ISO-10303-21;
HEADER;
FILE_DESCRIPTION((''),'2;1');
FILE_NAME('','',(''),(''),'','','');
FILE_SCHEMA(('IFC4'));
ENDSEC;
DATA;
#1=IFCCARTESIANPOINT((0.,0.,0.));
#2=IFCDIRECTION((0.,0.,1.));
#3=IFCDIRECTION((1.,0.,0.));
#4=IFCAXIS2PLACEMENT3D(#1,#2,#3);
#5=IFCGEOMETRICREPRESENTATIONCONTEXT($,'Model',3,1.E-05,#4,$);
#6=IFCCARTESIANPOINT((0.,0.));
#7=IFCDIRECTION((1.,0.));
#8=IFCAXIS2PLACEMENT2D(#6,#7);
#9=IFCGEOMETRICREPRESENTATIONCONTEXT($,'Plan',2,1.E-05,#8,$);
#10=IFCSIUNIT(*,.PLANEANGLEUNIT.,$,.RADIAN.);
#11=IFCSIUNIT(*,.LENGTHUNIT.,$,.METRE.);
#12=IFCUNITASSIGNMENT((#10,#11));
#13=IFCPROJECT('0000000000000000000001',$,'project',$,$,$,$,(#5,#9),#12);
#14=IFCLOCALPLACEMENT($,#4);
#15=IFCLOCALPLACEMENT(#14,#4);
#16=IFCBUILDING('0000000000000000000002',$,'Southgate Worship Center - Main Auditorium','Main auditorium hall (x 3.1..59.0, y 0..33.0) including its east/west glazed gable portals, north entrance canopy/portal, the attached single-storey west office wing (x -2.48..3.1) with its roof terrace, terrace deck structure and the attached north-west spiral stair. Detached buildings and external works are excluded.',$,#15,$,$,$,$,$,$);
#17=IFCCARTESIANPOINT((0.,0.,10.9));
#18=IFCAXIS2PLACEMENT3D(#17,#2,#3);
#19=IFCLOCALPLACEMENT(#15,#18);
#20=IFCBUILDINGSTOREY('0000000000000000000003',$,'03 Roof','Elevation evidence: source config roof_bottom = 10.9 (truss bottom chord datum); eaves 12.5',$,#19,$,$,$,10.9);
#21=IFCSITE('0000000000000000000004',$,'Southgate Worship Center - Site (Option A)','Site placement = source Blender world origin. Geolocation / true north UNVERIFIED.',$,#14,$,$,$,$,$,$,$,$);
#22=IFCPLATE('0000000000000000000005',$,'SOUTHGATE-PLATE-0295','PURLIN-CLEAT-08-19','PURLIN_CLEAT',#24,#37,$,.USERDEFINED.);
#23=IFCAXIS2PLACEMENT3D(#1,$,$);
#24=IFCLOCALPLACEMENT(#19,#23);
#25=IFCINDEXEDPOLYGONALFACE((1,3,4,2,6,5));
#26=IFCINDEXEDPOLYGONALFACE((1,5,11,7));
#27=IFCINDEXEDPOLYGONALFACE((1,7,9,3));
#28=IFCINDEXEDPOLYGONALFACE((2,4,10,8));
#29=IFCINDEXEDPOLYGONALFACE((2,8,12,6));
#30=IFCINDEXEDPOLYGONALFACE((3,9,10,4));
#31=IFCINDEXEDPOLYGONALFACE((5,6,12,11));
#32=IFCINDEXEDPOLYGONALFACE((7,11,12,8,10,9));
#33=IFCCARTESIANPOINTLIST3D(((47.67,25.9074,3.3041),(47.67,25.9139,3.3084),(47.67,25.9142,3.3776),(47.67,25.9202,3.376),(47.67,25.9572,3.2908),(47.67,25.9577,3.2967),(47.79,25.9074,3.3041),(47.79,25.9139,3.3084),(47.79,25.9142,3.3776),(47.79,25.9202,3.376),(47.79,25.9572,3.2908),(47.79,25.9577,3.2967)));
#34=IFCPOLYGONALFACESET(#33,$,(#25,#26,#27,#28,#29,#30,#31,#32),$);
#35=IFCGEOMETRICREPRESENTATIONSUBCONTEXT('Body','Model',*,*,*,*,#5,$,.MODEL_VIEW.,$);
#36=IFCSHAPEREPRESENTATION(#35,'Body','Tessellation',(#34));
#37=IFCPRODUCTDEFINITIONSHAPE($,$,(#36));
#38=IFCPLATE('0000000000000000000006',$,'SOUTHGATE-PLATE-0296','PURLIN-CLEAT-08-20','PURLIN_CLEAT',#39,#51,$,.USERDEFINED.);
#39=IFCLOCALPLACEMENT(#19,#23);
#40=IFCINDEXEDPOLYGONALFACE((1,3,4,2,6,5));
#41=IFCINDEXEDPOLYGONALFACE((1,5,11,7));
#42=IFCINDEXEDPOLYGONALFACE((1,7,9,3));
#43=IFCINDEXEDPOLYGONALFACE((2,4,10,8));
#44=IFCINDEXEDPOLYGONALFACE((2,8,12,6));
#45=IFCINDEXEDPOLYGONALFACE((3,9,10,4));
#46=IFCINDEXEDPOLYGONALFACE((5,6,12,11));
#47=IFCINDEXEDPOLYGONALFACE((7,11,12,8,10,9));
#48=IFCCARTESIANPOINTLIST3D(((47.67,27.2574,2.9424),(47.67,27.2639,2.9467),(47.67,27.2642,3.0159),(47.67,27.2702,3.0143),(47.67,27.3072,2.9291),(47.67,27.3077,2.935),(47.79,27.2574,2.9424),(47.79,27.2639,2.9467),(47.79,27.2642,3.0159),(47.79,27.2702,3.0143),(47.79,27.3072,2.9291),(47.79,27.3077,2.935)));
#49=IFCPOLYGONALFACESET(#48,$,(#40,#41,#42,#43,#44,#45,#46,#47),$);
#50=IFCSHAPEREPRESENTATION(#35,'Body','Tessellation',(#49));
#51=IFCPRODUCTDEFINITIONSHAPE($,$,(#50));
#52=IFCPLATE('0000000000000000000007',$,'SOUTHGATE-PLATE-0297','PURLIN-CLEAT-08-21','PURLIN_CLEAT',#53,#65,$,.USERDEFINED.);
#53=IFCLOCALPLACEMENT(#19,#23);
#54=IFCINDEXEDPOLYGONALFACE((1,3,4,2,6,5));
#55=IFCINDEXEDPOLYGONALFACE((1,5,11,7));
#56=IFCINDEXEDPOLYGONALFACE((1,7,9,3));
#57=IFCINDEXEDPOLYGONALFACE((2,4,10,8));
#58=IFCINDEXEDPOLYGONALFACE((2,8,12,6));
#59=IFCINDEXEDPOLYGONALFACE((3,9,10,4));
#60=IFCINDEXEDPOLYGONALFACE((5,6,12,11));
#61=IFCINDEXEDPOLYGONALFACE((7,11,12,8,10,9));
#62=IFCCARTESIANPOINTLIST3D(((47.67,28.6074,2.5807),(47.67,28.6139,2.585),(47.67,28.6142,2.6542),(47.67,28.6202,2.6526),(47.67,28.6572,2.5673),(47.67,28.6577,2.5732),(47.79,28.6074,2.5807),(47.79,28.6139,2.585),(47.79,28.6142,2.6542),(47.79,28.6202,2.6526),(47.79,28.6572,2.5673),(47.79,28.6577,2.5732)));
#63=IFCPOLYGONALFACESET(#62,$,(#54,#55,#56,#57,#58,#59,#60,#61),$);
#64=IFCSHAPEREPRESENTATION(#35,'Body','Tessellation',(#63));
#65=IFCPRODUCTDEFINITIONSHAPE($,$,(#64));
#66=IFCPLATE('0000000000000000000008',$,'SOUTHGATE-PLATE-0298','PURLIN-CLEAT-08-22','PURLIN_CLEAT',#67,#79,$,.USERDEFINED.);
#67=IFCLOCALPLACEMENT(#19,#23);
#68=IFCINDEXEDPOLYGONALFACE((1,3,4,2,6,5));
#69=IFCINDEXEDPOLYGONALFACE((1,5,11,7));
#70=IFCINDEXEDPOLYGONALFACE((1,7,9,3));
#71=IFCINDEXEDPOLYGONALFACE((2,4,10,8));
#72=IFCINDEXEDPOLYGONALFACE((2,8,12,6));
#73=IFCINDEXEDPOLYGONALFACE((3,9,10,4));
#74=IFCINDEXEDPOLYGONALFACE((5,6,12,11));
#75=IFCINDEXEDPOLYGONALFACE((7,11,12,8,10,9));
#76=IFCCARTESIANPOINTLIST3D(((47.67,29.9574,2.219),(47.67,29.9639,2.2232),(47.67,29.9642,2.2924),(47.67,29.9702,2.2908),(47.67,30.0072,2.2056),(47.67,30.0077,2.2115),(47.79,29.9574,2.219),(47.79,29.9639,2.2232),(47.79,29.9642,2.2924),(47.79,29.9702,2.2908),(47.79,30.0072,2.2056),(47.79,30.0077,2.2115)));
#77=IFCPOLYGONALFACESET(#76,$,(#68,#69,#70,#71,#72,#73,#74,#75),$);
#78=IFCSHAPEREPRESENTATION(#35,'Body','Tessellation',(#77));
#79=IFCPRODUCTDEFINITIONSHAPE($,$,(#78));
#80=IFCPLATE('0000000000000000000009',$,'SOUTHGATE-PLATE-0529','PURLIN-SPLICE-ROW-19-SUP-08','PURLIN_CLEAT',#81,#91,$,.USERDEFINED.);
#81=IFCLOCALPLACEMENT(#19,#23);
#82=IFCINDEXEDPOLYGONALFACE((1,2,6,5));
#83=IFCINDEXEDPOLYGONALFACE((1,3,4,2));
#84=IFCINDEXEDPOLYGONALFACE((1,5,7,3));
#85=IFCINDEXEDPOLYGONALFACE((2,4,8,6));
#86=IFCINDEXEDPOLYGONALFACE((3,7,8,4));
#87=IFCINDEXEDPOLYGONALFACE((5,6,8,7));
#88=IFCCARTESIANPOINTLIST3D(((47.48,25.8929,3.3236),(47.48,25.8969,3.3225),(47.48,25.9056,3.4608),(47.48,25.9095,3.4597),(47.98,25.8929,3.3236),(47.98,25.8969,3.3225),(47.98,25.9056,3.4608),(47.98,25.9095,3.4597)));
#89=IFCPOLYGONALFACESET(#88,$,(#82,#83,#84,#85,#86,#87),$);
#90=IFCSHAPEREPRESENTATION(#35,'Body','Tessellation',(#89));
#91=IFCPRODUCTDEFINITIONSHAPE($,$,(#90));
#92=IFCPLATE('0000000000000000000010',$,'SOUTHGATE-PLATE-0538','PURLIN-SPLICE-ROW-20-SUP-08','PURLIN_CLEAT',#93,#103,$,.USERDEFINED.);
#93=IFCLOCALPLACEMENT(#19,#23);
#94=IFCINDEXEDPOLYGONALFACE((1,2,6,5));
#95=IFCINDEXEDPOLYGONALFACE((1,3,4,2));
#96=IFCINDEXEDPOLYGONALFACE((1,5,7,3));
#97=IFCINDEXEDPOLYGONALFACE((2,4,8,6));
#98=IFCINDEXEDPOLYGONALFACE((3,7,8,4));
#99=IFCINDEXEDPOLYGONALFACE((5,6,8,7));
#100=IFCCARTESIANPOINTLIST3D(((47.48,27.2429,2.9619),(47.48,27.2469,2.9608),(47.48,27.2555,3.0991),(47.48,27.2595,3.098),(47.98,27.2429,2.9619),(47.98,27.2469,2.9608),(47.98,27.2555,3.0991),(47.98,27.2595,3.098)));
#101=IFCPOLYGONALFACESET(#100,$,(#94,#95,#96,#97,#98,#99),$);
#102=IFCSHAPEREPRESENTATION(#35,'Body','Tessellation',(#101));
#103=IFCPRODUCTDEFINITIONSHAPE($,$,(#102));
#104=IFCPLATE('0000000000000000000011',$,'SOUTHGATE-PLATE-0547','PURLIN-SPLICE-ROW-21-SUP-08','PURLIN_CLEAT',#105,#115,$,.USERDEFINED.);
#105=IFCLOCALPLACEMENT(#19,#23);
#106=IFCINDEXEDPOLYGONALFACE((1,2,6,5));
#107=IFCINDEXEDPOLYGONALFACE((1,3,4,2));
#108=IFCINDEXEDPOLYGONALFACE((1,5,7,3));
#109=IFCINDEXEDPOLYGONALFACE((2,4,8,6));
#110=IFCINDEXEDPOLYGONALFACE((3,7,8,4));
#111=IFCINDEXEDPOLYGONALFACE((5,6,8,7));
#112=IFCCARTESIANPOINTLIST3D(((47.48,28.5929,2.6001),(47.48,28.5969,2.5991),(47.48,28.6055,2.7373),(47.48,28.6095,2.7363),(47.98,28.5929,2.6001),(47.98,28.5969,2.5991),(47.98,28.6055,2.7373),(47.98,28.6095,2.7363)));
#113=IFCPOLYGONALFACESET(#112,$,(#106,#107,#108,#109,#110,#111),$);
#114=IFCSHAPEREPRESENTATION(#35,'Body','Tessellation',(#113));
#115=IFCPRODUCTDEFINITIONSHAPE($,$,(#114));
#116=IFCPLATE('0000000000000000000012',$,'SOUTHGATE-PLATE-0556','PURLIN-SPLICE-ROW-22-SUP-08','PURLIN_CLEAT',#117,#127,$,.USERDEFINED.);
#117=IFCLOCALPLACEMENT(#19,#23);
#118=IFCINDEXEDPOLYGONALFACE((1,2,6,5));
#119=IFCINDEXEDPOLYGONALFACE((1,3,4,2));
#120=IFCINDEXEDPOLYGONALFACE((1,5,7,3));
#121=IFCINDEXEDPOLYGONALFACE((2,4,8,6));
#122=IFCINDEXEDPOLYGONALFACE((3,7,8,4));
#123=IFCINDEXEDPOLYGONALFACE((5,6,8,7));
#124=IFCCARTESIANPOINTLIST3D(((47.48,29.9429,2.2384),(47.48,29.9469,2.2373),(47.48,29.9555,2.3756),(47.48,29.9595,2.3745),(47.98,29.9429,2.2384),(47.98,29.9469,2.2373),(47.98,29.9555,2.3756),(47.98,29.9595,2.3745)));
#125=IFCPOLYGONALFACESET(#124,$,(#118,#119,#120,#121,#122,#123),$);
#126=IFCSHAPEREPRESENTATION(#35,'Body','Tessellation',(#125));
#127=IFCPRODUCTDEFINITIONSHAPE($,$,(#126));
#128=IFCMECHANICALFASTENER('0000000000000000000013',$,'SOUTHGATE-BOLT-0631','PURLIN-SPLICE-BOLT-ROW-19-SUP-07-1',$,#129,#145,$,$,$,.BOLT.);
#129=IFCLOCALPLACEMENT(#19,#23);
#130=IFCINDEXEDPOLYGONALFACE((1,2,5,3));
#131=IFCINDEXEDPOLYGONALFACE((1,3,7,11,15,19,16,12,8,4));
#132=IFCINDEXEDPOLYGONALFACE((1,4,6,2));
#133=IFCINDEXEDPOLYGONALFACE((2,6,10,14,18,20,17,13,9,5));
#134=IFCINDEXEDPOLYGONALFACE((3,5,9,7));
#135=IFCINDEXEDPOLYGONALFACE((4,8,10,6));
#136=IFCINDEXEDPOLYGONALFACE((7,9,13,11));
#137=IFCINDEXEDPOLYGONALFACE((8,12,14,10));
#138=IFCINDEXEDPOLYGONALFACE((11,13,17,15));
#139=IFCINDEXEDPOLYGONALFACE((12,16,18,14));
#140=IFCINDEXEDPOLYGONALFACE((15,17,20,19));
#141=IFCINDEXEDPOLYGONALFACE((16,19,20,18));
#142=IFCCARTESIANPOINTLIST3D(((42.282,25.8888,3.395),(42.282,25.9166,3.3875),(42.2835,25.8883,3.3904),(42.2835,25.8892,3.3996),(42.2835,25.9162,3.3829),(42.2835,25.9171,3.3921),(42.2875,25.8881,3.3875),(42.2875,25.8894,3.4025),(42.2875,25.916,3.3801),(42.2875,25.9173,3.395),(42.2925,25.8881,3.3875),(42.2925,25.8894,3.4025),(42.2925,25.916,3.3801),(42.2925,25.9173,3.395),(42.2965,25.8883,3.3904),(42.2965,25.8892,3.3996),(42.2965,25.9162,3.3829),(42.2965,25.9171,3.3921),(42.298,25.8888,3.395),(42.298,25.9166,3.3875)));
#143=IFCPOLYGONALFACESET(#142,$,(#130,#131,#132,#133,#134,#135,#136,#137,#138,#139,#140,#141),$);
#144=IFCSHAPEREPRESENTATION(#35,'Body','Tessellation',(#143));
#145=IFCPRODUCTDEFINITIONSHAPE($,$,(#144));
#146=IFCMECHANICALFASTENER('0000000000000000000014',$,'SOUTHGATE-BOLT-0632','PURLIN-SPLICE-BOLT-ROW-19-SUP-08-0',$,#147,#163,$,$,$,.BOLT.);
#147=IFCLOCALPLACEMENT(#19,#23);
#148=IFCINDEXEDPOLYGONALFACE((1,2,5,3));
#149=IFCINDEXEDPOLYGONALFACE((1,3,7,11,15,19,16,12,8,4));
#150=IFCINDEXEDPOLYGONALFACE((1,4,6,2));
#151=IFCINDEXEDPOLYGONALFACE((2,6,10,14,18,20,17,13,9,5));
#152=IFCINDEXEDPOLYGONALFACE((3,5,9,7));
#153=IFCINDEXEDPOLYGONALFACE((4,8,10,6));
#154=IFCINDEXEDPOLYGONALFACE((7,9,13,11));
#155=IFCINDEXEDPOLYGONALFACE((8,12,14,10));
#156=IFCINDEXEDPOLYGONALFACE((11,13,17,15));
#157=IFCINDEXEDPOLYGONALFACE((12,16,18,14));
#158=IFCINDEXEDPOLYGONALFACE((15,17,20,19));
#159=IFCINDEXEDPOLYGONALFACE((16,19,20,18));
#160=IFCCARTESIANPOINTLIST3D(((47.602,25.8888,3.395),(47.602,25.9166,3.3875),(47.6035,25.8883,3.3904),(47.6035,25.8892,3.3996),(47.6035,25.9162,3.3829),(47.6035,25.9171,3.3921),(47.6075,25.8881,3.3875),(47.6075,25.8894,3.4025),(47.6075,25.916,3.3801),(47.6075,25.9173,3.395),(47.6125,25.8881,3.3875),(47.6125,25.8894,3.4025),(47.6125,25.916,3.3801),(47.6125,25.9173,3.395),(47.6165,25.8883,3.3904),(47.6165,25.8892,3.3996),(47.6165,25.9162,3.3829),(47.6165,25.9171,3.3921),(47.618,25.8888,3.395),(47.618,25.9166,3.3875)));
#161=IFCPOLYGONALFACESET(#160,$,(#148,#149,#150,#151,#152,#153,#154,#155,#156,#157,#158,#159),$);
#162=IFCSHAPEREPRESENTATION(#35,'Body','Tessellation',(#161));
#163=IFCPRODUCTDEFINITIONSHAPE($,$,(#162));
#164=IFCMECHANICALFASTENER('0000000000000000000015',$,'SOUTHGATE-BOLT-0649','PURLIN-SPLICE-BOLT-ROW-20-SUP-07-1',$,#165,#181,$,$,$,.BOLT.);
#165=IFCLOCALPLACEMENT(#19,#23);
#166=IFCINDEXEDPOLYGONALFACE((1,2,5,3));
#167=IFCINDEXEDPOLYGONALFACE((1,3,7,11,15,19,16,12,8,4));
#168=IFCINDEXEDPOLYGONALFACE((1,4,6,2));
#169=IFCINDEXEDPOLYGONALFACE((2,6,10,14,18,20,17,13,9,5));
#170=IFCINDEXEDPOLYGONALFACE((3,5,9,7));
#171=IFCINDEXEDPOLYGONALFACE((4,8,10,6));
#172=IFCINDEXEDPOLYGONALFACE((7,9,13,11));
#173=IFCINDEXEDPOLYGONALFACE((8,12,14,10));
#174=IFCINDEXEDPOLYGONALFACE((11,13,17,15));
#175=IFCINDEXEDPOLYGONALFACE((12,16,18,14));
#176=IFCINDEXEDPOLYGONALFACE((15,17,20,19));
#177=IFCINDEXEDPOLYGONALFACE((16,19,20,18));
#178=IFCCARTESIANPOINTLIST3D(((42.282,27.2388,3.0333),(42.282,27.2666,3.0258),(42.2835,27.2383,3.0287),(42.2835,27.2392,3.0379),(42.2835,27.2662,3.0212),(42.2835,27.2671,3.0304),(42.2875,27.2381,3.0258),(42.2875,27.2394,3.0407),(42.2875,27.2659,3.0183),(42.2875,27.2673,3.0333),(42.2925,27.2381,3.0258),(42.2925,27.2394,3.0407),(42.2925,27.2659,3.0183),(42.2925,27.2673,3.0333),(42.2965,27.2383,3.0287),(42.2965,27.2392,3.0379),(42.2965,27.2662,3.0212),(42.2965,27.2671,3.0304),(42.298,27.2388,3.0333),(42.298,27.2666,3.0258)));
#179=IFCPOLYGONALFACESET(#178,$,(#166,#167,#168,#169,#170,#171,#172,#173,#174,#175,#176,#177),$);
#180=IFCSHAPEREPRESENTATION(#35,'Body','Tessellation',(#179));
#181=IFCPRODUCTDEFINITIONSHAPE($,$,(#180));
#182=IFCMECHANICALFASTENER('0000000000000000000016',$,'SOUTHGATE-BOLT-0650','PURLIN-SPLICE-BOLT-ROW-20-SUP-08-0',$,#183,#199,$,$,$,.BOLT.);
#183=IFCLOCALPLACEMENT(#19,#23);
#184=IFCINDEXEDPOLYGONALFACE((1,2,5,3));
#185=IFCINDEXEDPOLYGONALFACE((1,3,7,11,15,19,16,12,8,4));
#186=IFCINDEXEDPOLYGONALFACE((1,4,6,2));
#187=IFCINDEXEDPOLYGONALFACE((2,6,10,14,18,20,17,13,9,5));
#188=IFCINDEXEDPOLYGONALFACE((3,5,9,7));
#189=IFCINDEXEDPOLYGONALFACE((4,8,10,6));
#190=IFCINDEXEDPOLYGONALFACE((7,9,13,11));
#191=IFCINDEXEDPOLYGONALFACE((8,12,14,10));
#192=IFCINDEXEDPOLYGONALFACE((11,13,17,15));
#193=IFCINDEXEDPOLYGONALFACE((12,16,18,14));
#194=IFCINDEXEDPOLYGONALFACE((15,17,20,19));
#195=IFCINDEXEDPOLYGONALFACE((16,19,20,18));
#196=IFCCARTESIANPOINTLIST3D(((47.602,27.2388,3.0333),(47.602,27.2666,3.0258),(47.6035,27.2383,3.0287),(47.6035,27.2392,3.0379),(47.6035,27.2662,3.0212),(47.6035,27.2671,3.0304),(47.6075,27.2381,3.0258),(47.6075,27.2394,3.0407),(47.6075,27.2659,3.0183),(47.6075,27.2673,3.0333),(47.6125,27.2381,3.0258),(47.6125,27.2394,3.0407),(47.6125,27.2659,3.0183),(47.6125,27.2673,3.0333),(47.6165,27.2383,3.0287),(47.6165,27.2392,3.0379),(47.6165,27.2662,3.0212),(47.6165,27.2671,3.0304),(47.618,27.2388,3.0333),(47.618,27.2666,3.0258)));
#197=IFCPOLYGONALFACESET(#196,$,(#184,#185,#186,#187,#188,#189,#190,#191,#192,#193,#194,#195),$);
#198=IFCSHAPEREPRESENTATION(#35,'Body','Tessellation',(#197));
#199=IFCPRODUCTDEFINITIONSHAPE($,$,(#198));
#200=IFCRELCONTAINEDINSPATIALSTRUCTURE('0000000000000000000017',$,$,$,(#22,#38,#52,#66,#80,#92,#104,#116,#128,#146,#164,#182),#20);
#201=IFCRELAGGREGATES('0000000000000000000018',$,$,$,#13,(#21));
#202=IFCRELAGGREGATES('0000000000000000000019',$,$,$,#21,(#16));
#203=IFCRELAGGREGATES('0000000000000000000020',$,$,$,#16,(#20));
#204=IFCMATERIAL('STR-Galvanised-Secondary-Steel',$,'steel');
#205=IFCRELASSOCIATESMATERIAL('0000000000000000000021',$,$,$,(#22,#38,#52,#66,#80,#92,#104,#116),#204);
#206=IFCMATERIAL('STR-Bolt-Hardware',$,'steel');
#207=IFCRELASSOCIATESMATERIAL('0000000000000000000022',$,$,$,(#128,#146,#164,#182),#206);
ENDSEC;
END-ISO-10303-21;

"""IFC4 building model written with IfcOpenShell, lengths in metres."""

from ifc_helpers import new_model, si_unit, frame, origin_with_axes, origin_2d_with_axis, place, context, subcontext, project, spatial, indexed_curve, outline, extrude, clip, halfspace, material, element, save


model = new_model("IFC4")

# Units and contexts
model_context = context("Model", 3, precision=1e-05, world=origin_with_axes())
plan_context = context("Plan", 2, precision=1e-05, world=origin_2d_with_axis())
body_context = subcontext(model_context, "Body", "Model", "MODEL_VIEW")
ifc_project = project(units=[si_unit("PLANEANGLEUNIT", "RADIAN"), si_unit("LENGTHUNIT", "METRE")], contexts=[model_context, plan_context])

# Site, building, storey
site_placement = place(None, origin_with_axes())
site = spatial("IfcSite", under=ifc_project, at=site_placement, Name="Southgate Worship Center - Site (Option A)", Description="Site placement = source Blender world origin. Geolocation / true north UNVERIFIED.")
building_placement = place(site_placement, origin_with_axes())
building = spatial("IfcBuilding", under=site, at=building_placement, Name="Southgate Worship Center - Main Auditorium", Description="Main auditorium hall (x 3.1..59.0, y 0..33.0) including its east/west glazed gable portals, north entrance canopy/portal, the attached single-storey west office wing (x -2.48..3.1) with its roof terrace, terrace deck structure and the attached north-west spiral stair. Detached buildings and external works are excluded.")
storey_placement = place(building_placement, frame((0.0, 0.0, 10.9), z_axis=(0.0, 0.0, 1.0), x_axis=(1.0, 0.0, 0.0)))
storey = spatial("IfcBuildingStorey", under=building, at=storey_placement, Name="03 Roof", Description="Elevation evidence: source config roof_bottom = 10.9 (truss bottom chord datum); eaves 12.5", Elevation=10.9)

# Shared definitions
ifc_material_1 = material(Name="STR-Galvanised-Secondary-Steel", Category="steel")

# Plates
for number, where, z_axis, x_axis, name, description in (
    (1, (47.67, 25.9074, 3.2908), (1.0, 0.0, 0.0), (0.0, 1.0, 0.0), "SOUTHGATE-PLATE-0295", "PURLIN-CLEAT-08-19"),
    (2, (47.67, 27.2574, 2.9291), (1.0, 0.0, 0.0), (0.0, 1.0, 0.0), "SOUTHGATE-PLATE-0296", "PURLIN-CLEAT-08-20"),
    (3, (47.67, 28.6074, 2.5673), (1.0, 0.0, 0.0), (0.0, 1.0, 0.0), "SOUTHGATE-PLATE-0297", "PURLIN-CLEAT-08-21"),
    (4, (47.67, 29.9574, 2.2056), (1.0, 0.0, 0.0), (0.0, 1.0, 0.0), "SOUTHGATE-PLATE-0298", "PURLIN-CLEAT-08-22"),
):
    element("IfcPlate", number, at=place(storey_placement, frame(where, z_axis=z_axis, x_axis=x_axis)), inside=storey, material=ifc_material_1, Name=name, Description=description, ObjectType="PURLIN_CLEAT", PredefinedType="USERDEFINED", context=body_context, shape_type="SweptSolid", body=[
        extrude(outline(indexed_curve([(0.0, 0.0), (0.0498, -0.0133), (0.0503, -0.0075), (0.0065, 0.0043), (0.0128, 0.0719), (0.0068, 0.0735), (0.0, 0.0)], self_intersect=False)), frame((0.0, 0.0133, 0.0), z_axis=(0.0, 0.0, 1.0), x_axis=(1.0, 0.0, 0.0)), (0.0, 0.0, 1.0), 0.12),
    ])
plate_placement = place(storey_placement, frame((47.48, 25.8929, 3.3225), z_axis=(1.0, 0.0, 0.0), x_axis=(0.0, 1.0, 0.0)))
element("IfcPlate", 5, at=plate_placement, inside=storey, material=ifc_material_1, Name="SOUTHGATE-PLATE-0529", Description="PURLIN-SPLICE-ROW-19-SUP-08", ObjectType="PURLIN_CLEAT", PredefinedType="USERDEFINED", context=body_context, shape_type="SweptSolid", body=[
    extrude(outline(indexed_curve([(0.0, 0.0), (0.004, -0.0011), (0.0167, 0.1361), (0.0127, 0.1372), (0.0, 0.0)], self_intersect=False)), frame((0.0, 0.0011, 0.0), z_axis=(0.0, 0.0, 1.0), x_axis=(1.0, 0.0, 0.0)), (0.0, 0.0, 1.0), 0.5),
])
for number, where, z_axis, x_axis, name, description in (
    (6, (47.48, 27.2429, 2.9608), (1.0, 0.0, 0.0), (0.0, 1.0, 0.0), "SOUTHGATE-PLATE-0538", "PURLIN-SPLICE-ROW-20-SUP-08"),
    (7, (47.48, 28.5929, 2.5991), (1.0, 0.0, 0.0), (0.0, 1.0, 0.0), "SOUTHGATE-PLATE-0547", "PURLIN-SPLICE-ROW-21-SUP-08"),
    (8, (47.48, 29.9429, 2.2373), (1.0, 0.0, 0.0), (0.0, 1.0, 0.0), "SOUTHGATE-PLATE-0556", "PURLIN-SPLICE-ROW-22-SUP-08"),
):
    element("IfcPlate", number, at=place(storey_placement, frame(where, z_axis=z_axis, x_axis=x_axis)), inside=storey, material=ifc_material_1, Name=name, Description=description, ObjectType="PURLIN_CLEAT", PredefinedType="USERDEFINED", context=body_context, shape_type="SweptSolid", body=[
        extrude(outline(indexed_curve([(0.0, 0.0), (0.004, -0.0011), (0.0167, 0.1361), (0.0127, 0.1372), (0.0, 0.0)], self_intersect=False)), frame((0.0, 0.0011, 0.0), z_axis=(0.0, 0.0, 1.0), x_axis=(1.0, 0.0, 0.0)), (0.0, 0.0, 1.0), 0.5),
    ])

# Mechanical fasteners
ifc_material_2 = material(Name="STR-Bolt-Hardware", Category="steel")
mechanical_fastener_1_placement = place(storey_placement, frame((42.282, 25.8881, 3.3801), z_axis=(0.0, 0.0, 1.0), x_axis=(1.0, 0.0, 0.0)))
element("IfcMechanicalFastener", 9, at=mechanical_fastener_1_placement, inside=storey, material=ifc_material_2, Name="SOUTHGATE-BOLT-0631", Description="PURLIN-SPLICE-BOLT-ROW-19-SUP-07-1", PredefinedType="BOLT", context=body_context, shape_type="Clipping", body=[
    clip(clip(extrude(outline(indexed_curve([(0.0, 0.0), (0.004, 0.0028), (0.0055, 0.0074), (0.004, 0.0119), (0.0, 0.0148), (-0.0049, 0.0148), (-0.0089, 0.0119), (-0.0105, 0.0074), (-0.0089, 0.0028), (-0.0049, 0.0), (0.0, 0.0)], self_intersect=False)), frame((0.0055, -0.0025, 0.0081), z_axis=(0.0, 0.965924, -0.258824), x_axis=(-1.0, 0.0, 0.0)), (0.0, 0.0, 1.0), 0.0314), halfspace(frame((0.008, 0.0007, 0.0149), z_axis=(0.0, -0.995763, 0.09196), x_axis=(1.0, 0.0, 0.0)), False)), halfspace(frame((0.008, 0.0285, 0.0074), z_axis=(0.0, 0.995763, -0.09196), x_axis=(-1.0, 0.0, 0.0)), False)),
])
mechanical_fastener_2_placement = place(storey_placement, frame((47.602, 25.8881, 3.3801), z_axis=(0.0, 0.0, 1.0), x_axis=(1.0, 0.0, 0.0)))
element("IfcMechanicalFastener", 10, at=mechanical_fastener_2_placement, inside=storey, material=ifc_material_2, Name="SOUTHGATE-BOLT-0632", Description="PURLIN-SPLICE-BOLT-ROW-19-SUP-08-0", PredefinedType="BOLT", context=body_context, shape_type="Clipping", body=[
    clip(clip(extrude(outline(indexed_curve([(0.0, 0.0), (0.004, 0.0028), (0.0055, 0.0074), (0.004, 0.0119), (0.0, 0.0148), (-0.0049, 0.0148), (-0.0089, 0.0119), (-0.0105, 0.0074), (-0.0089, 0.0028), (-0.0049, 0.0), (0.0, 0.0)], self_intersect=False)), frame((0.0055, -0.0025, 0.0081), z_axis=(0.0, 0.965924, -0.258824), x_axis=(-1.0, 0.0, 0.0)), (0.0, 0.0, 1.0), 0.0314), halfspace(frame((0.008, 0.0007, 0.0149), z_axis=(0.0, -0.995763, 0.09196), x_axis=(1.0, 0.0, 0.0)), False)), halfspace(frame((0.008, 0.0285, 0.0074), z_axis=(0.0, 0.995763, -0.09196), x_axis=(-1.0, 0.0, 0.0)), False)),
])
mechanical_fastener_3_placement = place(storey_placement, frame((42.282, 27.2381, 3.0183), z_axis=(0.0, 0.0, 1.0), x_axis=(1.0, 0.0, 0.0)))
element("IfcMechanicalFastener", 11, at=mechanical_fastener_3_placement, inside=storey, material=ifc_material_2, Name="SOUTHGATE-BOLT-0649", Description="PURLIN-SPLICE-BOLT-ROW-20-SUP-07-1", PredefinedType="BOLT", context=body_context, shape_type="Clipping", body=[
    clip(clip(extrude(outline(indexed_curve([(0.0, 0.0), (0.004, 0.0028), (0.0055, 0.0074), (0.004, 0.0119), (0.0, 0.0148), (-0.0049, 0.0148), (-0.0089, 0.0119), (-0.0105, 0.0074), (-0.0089, 0.0028), (-0.0049, 0.0), (0.0, 0.0)], self_intersect=False)), frame((0.0055, -0.0025, 0.0082), z_axis=(0.0, 0.965924, -0.258824), x_axis=(-1.0, 0.0, 0.0)), (0.0, 0.0, 1.0), 0.0314), halfspace(frame((0.008, 0.0007, 0.015), z_axis=(0.0, -0.995763, 0.09196), x_axis=(1.0, 0.0, 0.0)), False)), halfspace(frame((0.008, 0.0285, 0.0075), z_axis=(0.0, 0.995763, -0.091956), x_axis=(-1.0, 0.0, 0.0)), False)),
])
mechanical_fastener_4_placement = place(storey_placement, frame((47.602, 27.2381, 3.0183), z_axis=(0.0, 0.0, 1.0), x_axis=(1.0, 0.0, 0.0)))
element("IfcMechanicalFastener", 12, at=mechanical_fastener_4_placement, inside=storey, material=ifc_material_2, Name="SOUTHGATE-BOLT-0650", Description="PURLIN-SPLICE-BOLT-ROW-20-SUP-08-0", PredefinedType="BOLT", context=body_context, shape_type="Clipping", body=[
    clip(clip(extrude(outline(indexed_curve([(0.0, 0.0), (0.004, 0.0028), (0.0055, 0.0074), (0.004, 0.0119), (0.0, 0.0148), (-0.0049, 0.0148), (-0.0089, 0.0119), (-0.0105, 0.0074), (-0.0089, 0.0028), (-0.0049, 0.0), (0.0, 0.0)], self_intersect=False)), frame((0.0055, -0.0025, 0.0082), z_axis=(0.0, 0.965924, -0.258824), x_axis=(-1.0, 0.0, 0.0)), (0.0, 0.0, 1.0), 0.0314), halfspace(frame((0.008, 0.0007, 0.015), z_axis=(0.0, -0.995763, 0.09196), x_axis=(1.0, 0.0, 0.0)), False)), halfspace(frame((0.008, 0.0285, 0.0075), z_axis=(0.0, 0.995763, -0.091956), x_axis=(-1.0, 0.0, 0.0)), False)),
])

save(model, "model.ifc")
